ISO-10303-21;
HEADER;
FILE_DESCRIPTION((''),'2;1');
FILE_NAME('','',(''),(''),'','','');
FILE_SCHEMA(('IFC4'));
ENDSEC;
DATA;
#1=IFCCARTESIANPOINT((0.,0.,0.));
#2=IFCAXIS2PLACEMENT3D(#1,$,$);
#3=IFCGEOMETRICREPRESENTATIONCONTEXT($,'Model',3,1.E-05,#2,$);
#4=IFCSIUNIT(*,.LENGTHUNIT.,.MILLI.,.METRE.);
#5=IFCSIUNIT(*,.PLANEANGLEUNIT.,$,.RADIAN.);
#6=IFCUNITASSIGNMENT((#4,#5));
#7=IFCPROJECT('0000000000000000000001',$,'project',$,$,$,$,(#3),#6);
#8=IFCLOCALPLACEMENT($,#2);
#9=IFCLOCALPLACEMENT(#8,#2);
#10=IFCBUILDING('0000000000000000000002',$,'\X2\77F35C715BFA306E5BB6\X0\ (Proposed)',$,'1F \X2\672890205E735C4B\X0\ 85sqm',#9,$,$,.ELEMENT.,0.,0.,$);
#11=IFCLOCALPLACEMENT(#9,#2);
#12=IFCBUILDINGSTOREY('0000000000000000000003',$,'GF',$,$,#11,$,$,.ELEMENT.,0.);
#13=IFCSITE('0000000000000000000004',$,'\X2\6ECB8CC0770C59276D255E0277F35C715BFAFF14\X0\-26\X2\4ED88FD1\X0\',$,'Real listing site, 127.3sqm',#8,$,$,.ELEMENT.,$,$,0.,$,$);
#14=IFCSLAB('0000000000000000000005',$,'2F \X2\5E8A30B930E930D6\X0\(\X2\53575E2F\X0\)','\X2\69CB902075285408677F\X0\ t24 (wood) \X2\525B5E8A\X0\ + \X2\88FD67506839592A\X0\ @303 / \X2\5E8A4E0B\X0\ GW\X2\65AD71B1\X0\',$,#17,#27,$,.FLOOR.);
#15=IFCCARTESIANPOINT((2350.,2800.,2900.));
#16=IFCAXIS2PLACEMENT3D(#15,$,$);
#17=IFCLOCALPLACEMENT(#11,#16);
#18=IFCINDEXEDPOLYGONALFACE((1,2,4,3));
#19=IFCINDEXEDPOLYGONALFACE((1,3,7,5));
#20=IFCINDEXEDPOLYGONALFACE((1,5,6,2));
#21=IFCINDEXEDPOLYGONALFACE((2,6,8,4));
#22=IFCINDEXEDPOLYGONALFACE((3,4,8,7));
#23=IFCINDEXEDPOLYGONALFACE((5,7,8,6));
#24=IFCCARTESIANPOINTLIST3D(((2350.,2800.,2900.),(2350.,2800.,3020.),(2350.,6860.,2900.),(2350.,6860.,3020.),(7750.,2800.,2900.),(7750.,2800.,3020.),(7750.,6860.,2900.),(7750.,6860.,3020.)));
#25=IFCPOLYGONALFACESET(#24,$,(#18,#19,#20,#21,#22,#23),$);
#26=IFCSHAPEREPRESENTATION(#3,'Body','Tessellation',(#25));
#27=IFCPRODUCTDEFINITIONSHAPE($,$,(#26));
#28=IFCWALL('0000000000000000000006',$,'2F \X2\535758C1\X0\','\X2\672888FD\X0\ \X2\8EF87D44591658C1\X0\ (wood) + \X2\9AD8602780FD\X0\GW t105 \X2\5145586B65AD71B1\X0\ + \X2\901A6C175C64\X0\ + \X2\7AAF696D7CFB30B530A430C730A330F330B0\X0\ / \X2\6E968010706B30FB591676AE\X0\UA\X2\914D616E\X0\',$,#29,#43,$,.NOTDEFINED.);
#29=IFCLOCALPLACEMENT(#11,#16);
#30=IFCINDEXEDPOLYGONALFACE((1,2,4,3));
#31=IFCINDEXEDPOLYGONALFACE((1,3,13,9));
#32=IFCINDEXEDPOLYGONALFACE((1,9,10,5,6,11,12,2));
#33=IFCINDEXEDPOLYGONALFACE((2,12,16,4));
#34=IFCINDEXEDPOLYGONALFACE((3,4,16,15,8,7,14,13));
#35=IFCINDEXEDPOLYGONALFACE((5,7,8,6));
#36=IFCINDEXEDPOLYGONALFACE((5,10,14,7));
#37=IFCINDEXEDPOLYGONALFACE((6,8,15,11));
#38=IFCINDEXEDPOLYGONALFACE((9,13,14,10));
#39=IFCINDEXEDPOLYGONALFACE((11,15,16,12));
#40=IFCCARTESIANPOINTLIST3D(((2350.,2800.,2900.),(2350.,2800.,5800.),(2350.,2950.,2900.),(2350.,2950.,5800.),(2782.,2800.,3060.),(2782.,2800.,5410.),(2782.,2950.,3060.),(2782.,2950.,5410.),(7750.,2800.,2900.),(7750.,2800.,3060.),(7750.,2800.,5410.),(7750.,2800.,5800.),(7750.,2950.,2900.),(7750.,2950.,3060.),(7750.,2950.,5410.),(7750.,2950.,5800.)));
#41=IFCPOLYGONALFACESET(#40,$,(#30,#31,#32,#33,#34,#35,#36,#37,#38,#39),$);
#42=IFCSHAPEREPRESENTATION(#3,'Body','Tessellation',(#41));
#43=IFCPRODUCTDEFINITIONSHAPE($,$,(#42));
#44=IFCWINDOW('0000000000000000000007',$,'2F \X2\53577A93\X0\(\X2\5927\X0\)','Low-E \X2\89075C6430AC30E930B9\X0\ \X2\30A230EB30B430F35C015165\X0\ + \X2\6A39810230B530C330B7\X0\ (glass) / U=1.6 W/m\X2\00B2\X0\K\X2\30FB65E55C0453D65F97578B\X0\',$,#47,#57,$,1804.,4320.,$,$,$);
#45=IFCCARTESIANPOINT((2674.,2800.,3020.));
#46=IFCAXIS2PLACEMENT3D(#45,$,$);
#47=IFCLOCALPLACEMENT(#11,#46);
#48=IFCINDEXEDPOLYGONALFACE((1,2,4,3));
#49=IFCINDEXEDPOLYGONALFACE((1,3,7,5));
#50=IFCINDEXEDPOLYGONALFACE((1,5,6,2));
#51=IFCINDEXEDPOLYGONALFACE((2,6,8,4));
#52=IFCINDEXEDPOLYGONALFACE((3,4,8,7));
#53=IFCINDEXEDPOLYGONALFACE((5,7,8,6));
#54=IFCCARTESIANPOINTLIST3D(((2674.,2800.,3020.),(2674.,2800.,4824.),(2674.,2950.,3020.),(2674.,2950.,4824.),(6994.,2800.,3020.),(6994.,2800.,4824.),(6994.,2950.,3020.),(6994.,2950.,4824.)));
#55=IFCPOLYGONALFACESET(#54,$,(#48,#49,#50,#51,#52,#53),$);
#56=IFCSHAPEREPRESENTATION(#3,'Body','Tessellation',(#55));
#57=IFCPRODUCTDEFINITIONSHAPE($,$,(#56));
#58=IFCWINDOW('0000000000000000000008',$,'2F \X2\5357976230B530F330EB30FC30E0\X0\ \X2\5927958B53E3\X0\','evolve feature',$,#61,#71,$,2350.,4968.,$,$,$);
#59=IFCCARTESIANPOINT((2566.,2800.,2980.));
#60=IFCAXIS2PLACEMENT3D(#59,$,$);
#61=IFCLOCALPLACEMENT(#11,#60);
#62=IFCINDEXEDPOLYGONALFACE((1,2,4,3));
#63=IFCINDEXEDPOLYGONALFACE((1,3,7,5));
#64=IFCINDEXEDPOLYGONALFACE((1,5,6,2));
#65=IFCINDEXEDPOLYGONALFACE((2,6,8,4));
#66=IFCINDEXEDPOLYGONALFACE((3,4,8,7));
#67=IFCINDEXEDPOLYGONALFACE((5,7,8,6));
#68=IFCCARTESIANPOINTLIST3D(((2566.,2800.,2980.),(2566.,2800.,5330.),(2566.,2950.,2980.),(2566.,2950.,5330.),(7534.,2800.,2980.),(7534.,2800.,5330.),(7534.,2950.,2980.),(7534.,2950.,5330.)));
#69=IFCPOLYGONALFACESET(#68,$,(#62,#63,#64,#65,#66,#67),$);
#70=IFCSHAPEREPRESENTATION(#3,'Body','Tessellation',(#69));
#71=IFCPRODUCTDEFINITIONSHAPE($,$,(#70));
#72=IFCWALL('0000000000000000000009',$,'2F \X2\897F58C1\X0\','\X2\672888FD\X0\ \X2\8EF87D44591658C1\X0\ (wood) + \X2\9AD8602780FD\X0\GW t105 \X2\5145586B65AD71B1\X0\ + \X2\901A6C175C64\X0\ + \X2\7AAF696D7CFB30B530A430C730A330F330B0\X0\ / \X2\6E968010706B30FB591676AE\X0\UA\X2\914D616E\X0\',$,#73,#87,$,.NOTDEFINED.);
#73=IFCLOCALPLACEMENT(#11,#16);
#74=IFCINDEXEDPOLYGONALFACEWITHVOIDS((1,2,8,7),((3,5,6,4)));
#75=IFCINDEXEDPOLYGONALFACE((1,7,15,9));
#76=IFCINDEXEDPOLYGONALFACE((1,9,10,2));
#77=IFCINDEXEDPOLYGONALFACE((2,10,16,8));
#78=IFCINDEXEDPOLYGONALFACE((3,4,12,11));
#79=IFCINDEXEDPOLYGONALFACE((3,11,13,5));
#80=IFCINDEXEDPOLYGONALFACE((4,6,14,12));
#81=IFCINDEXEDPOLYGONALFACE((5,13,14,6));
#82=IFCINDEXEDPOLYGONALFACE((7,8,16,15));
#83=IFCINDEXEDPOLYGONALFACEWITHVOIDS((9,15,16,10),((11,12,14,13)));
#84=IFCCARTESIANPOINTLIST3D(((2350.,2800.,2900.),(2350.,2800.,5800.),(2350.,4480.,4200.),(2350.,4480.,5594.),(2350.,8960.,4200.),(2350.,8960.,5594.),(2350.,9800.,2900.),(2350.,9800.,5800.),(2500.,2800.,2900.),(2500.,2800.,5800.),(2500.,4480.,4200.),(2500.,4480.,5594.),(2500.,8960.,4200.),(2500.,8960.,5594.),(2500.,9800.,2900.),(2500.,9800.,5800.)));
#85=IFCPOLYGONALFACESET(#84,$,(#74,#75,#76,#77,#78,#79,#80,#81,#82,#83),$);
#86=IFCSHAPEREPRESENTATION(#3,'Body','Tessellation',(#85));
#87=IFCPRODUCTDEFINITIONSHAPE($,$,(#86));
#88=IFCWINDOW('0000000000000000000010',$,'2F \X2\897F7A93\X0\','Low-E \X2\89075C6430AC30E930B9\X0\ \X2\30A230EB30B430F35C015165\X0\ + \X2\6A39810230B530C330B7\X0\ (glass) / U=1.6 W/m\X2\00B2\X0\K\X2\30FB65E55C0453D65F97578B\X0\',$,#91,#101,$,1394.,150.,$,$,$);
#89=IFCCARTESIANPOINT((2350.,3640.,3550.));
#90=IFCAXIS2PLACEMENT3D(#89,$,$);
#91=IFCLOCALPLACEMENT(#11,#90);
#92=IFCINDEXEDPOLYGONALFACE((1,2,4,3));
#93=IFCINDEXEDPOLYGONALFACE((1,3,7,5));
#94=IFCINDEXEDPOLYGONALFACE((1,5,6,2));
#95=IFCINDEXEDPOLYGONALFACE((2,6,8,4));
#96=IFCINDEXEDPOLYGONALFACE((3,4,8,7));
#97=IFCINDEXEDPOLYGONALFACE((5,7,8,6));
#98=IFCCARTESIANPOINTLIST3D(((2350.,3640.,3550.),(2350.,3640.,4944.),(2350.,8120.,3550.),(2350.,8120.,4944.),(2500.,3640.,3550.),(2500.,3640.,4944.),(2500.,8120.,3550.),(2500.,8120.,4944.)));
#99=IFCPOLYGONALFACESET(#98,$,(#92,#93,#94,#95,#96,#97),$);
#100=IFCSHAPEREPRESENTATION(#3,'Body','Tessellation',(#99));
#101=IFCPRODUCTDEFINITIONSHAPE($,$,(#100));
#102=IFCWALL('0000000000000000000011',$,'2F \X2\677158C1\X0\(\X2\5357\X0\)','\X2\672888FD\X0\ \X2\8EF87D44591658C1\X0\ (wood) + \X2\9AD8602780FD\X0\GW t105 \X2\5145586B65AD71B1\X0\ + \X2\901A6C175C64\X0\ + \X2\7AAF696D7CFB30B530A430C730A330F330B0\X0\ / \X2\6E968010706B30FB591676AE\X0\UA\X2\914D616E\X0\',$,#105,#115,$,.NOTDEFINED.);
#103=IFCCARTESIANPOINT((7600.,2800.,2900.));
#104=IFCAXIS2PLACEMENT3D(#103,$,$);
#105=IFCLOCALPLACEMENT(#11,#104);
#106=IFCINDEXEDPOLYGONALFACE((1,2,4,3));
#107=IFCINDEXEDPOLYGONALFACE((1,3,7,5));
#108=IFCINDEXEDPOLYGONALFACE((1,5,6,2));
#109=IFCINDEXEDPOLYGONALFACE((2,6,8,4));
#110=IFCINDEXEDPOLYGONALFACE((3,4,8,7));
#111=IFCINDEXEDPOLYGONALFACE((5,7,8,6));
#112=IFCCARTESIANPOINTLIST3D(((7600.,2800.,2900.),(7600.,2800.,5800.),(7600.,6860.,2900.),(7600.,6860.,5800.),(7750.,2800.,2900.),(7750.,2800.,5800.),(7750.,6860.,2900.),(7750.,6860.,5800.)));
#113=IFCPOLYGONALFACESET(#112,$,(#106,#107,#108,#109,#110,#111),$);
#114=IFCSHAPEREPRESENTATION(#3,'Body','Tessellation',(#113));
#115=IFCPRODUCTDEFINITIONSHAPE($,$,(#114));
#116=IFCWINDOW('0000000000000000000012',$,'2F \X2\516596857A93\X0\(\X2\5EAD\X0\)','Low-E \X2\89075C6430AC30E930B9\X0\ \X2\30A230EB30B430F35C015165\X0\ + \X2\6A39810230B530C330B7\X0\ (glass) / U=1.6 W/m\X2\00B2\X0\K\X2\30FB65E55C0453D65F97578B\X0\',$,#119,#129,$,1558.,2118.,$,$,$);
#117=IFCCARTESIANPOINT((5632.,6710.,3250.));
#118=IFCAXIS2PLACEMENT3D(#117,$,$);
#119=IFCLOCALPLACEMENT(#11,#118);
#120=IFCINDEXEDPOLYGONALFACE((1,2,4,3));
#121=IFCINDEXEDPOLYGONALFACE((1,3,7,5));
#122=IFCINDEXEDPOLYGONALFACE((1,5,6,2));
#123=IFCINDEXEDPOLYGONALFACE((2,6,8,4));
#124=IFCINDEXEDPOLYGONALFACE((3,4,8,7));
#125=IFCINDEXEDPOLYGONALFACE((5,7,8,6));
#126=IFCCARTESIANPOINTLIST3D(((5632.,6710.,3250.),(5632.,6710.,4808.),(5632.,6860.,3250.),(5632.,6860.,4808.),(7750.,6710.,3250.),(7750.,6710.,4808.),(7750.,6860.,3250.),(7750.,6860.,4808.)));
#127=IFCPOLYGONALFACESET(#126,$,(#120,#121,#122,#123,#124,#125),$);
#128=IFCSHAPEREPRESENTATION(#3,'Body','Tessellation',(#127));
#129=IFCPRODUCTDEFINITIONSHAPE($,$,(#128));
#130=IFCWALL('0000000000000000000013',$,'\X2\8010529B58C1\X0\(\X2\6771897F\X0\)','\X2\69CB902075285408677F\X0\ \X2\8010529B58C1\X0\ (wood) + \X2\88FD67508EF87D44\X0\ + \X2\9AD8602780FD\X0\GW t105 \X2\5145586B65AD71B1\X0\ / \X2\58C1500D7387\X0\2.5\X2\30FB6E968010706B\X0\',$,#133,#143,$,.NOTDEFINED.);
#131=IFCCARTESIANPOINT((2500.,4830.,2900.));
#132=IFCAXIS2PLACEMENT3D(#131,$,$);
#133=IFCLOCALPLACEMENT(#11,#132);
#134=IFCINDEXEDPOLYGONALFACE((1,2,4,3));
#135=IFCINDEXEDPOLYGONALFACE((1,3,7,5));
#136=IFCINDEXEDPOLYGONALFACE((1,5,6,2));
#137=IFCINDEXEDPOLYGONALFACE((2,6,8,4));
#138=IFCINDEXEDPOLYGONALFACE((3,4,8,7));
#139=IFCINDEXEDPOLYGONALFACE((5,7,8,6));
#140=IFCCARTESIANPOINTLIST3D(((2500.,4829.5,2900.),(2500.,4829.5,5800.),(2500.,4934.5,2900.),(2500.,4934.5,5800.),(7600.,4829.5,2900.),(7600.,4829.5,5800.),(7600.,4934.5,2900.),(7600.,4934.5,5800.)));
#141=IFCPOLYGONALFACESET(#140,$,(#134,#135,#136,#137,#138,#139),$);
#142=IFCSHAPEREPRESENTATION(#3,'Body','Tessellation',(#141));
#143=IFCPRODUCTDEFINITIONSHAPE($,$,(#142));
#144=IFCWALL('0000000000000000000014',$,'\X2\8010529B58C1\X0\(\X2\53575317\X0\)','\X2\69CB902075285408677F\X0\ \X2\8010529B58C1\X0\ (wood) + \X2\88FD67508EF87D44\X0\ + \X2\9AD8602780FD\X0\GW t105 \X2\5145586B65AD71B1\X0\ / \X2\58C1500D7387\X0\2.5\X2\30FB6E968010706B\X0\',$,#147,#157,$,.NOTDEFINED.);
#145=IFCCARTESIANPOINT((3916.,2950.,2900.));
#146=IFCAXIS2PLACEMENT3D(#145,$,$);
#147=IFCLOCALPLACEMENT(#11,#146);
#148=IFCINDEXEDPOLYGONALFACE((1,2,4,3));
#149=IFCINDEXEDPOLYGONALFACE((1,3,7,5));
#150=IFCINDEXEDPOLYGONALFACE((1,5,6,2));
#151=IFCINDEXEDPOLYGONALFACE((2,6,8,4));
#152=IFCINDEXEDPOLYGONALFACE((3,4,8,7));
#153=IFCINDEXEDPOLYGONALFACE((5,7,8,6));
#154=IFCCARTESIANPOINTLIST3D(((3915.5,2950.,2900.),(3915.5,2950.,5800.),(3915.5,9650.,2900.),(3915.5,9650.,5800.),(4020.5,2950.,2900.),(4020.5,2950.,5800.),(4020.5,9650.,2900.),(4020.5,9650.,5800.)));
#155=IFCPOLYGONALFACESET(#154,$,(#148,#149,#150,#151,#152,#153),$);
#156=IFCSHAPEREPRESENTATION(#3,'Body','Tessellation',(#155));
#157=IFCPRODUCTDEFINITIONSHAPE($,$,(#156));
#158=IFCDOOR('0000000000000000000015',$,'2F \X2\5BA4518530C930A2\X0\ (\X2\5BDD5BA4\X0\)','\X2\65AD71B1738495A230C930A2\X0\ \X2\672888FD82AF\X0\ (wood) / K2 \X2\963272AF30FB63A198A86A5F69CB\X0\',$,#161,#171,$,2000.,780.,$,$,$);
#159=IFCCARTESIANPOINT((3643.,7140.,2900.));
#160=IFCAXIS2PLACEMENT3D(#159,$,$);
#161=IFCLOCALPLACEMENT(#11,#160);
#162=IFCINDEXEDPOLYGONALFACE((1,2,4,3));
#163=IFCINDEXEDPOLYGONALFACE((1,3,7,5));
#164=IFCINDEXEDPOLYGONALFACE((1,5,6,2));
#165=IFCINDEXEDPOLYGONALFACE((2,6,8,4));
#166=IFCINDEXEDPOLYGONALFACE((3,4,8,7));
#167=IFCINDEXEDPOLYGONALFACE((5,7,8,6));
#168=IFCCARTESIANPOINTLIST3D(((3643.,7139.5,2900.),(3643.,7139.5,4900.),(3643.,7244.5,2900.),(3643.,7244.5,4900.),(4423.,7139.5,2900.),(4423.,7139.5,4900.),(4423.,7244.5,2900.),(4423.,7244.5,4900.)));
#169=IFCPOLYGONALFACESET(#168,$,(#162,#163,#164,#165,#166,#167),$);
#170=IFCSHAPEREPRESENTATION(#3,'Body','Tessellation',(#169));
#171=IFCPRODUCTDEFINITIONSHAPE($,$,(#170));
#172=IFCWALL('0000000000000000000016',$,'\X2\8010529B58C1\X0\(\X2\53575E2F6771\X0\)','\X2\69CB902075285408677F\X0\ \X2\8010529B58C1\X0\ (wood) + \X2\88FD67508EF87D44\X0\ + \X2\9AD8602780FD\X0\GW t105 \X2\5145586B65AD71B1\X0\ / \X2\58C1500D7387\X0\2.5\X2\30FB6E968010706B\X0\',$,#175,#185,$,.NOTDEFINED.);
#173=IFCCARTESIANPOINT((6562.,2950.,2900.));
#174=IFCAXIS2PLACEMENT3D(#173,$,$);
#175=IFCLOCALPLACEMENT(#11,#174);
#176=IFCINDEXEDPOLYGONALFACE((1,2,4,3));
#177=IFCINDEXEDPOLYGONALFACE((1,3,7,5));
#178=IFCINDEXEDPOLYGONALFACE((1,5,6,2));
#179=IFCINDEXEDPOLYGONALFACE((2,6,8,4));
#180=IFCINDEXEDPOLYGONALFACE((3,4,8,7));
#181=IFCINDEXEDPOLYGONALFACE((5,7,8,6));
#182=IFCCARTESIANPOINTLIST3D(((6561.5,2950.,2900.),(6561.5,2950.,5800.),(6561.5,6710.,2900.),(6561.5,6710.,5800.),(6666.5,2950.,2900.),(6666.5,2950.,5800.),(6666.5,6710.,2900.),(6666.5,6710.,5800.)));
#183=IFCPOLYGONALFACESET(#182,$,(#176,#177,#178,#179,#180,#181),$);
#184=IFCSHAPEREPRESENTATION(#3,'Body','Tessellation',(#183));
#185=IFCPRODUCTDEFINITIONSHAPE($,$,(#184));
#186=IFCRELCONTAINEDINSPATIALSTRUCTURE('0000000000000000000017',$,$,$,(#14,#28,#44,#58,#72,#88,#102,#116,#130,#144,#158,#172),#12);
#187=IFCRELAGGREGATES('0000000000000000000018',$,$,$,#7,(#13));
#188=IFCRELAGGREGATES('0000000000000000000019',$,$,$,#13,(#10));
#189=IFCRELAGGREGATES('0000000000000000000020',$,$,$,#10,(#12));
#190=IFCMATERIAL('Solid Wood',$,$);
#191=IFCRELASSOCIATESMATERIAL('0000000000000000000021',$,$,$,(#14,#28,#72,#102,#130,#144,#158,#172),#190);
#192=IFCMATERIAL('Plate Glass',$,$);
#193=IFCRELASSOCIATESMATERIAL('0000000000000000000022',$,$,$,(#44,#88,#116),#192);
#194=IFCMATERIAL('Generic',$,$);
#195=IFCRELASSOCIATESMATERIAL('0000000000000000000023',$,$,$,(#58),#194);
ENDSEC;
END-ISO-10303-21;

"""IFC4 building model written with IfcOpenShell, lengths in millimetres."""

from ifc_helpers import new_model, si_unit, frame, frame_2d, origin, place, context, project, spatial, rectangle, extrude, material, element, fill, save


model = new_model("IFC4")

# Units and contexts
model_context = context("Model", 3, precision=1e-05, world=origin())
ifc_project = project(units=[si_unit("LENGTHUNIT", "METRE", prefix="MILLI"), si_unit("PLANEANGLEUNIT", "RADIAN")], contexts=[model_context])

# Site, building, storey
site_placement = place(None, origin())
site = spatial("IfcSite", under=ifc_project, at=site_placement, Name="滋賀県大津市石山寺４-26付近", ObjectType="Real listing site, 127.3sqm", CompositionType="ELEMENT", RefElevation=0.0)
building_placement = place(site_placement, origin())
building = spatial("IfcBuilding", under=site, at=building_placement, Name="石山寺の家 (Proposed)", ObjectType="1F 木造平屋 85sqm", CompositionType="ELEMENT", ElevationOfRefHeight=0.0, ElevationOfTerrain=0.0)
storey_placement = place(building_placement, origin())
storey = spatial("IfcBuildingStorey", under=building, at=storey_placement, Name="GF", CompositionType="ELEMENT", Elevation=0.0)

# Slab
ifc_material_1 = material(Name="Solid Wood")
slab_placement = place(storey_placement, frame((2350.0, 2800.0, 2900.0)))
element("IfcSlab", 1, at=slab_placement, inside=storey, material=ifc_material_1, Name="2F 床スラブ(南帯)", Description="構造用合板 t24 (wood) 剛床 + 製材根太 @303 / 床下 GW断熱", PredefinedType="FLOOR", context=model_context, shape_type="SweptSolid", body=[
    extrude(rectangle(XDim=5400.0, YDim=4060.0, at=frame_2d((2700.0, 2030.0))), frame((2350.0, 2800.0, 2900.0)), (0.0, 0.0, 1.0), 120.0),
])

# Wall, openings, windows
wall_1_placement = place(storey_placement, frame((2350.0, 2800.0, 2900.0)))
wall_1 = element("IfcWall", 2, at=wall_1_placement, inside=storey, material=ifc_material_1, Name="2F 南壁", Description="木製 軸組外壁 (wood) + 高性能GW t105 充填断熱 + 通気層 + 窯業系サイディング / 準耐火・外皮UA配慮", PredefinedType="NOTDEFINED", context=model_context, shape_type="SweptSolid", body=[
    extrude(rectangle(XDim=5400.0, YDim=150.0, at=frame_2d((2700.0, 75.0))), frame((2350.0, 2800.0, 2900.0)), (0.0, 0.0, 1.0), 2900.0),
])
opening_1_placement = place(storey_placement, frame((2674.0, 2800.0, 3020.0)))
opening_1 = element("IfcOpeningElement", 3, at=opening_1_placement, cuts=wall_1, PredefinedType="NOTDEFINED", context=model_context, shape_type="SweptSolid", body=[
    extrude(rectangle(XDim=4320.0, YDim=150.0, at=frame_2d((2160.0, 75.0))), frame((2674.0, 2800.0, 3020.0)), (0.0, 0.0, 1.0), 1804.0),
])
opening_2_placement = place(storey_placement, frame((2566.0, 2800.0, 2980.0)))
opening_2 = element("IfcOpeningElement", 4, at=opening_2_placement, cuts=wall_1, PredefinedType="NOTDEFINED", context=model_context, shape_type="SweptSolid", body=[
    extrude(rectangle(XDim=4968.0, YDim=150.0, at=frame_2d((2484.0, 75.0))), frame((2566.0, 2800.0, 2980.0)), (0.0, 0.0, 1.0), 2350.0),
])
ifc_material_2 = material(Name="Plate Glass")
window_1_placement = place(storey_placement, frame((2674.0, 2800.0, 3020.0)))
window_1 = element("IfcWindow", 5, at=window_1_placement, inside=storey, material=ifc_material_2, Name="2F 南窓(大)", Description="Low-E 複層ガラス アルゴン封入 + 樹脂サッシ (glass) / U=1.6 W/m²K・日射取得型", OverallHeight=1804.0, OverallWidth=4320.0, context=model_context, shape_type="SweptSolid", body=[
    extrude(rectangle(XDim=4320.0, YDim=150.0, at=frame_2d((2160.0, 75.0))), frame((2674.0, 2800.0, 3020.0)), (0.0, 0.0, 1.0), 1804.0),
])
fill(opening_1, window_1)
ifc_material_3 = material(Name="Generic")
window_2_placement = place(storey_placement, frame((2566.0, 2800.0, 2980.0)))
window_2 = element("IfcWindow", 6, at=window_2_placement, inside=storey, material=ifc_material_3, Name="2F 南面サンルーム 大開口", Description="evolve feature", OverallHeight=2350.0, OverallWidth=4968.0, context=model_context, shape_type="SweptSolid", body=[
    extrude(rectangle(XDim=4968.0, YDim=150.0, at=frame_2d((2484.0, 75.0))), frame((2566.0, 2800.0, 2980.0)), (0.0, 0.0, 1.0), 2350.0),
])
fill(opening_2, window_2)

# Walls, openings, windows
wall_2_placement = place(storey_placement, frame((2350.0, 2800.0, 2900.0)))
wall_2 = element("IfcWall", 7, at=wall_2_placement, inside=storey, material=ifc_material_1, Name="2F 西壁", Description="木製 軸組外壁 (wood) + 高性能GW t105 充填断熱 + 通気層 + 窯業系サイディング / 準耐火・外皮UA配慮", PredefinedType="NOTDEFINED", context=model_context, shape_type="SweptSolid", body=[
    extrude(rectangle(XDim=150.0, YDim=7000.0, at=frame_2d((75.0, 3500.0))), frame((2350.0, 2800.0, 2900.0)), (0.0, 0.0, 1.0), 2900.0),
])
opening_3_placement = place(storey_placement, frame((2350.0, 3640.0, 3550.0)))
opening_3 = element("IfcOpeningElement", 8, at=opening_3_placement, cuts=wall_2, PredefinedType="NOTDEFINED", context=model_context, shape_type="SweptSolid", body=[
    extrude(rectangle(XDim=150.0, YDim=4480.0, at=frame_2d((75.0, 2240.0))), frame((2350.0, 3640.0, 3550.0)), (0.0, 0.0, 1.0), 1394.0),
])
window_3_placement = place(storey_placement, frame((2350.0, 3640.0, 3550.0)))
window_3 = element("IfcWindow", 9, at=window_3_placement, inside=storey, material=ifc_material_2, Name="2F 西窓", Description="Low-E 複層ガラス アルゴン封入 + 樹脂サッシ (glass) / U=1.6 W/m²K・日射取得型", OverallHeight=1394.0, OverallWidth=150.0, context=model_context, shape_type="SweptSolid", body=[
    extrude(rectangle(XDim=150.0, YDim=4480.0, at=frame_2d((75.0, 2240.0))), frame((2350.0, 3640.0, 3550.0)), (0.0, 0.0, 1.0), 1394.0),
])
fill(opening_3, window_3)
wall_3_placement = place(storey_placement, frame((7600.0, 2800.0, 2900.0)))
wall_3 = element("IfcWall", 10, at=wall_3_placement, inside=storey, material=ifc_material_1, Name="2F 東壁(南)", Description="木製 軸組外壁 (wood) + 高性能GW t105 充填断熱 + 通気層 + 窯業系サイディング / 準耐火・外皮UA配慮", PredefinedType="NOTDEFINED", context=model_context, shape_type="SweptSolid", body=[
    extrude(rectangle(XDim=150.0, YDim=4060.0, at=frame_2d((75.0, 2030.0))), frame((7600.0, 2800.0, 2900.0)), (0.0, 0.0, 1.0), 2900.0),
])
opening_4_placement = place(storey_placement, frame((5632.0, 6710.0, 3250.0)))
opening_4 = element("IfcOpeningElement", 11, at=opening_4_placement, cuts=wall_3, PredefinedType="NOTDEFINED", context=model_context, shape_type="SweptSolid", body=[
    extrude(rectangle(XDim=2118.0, YDim=150.0, at=frame_2d((1059.0, 75.0))), frame((5632.0, 6710.0, 3250.0)), (0.0, 0.0, 1.0), 1558.0),
])
window_4_placement = place(storey_placement, frame((5632.0, 6710.0, 3250.0)))
window_4 = element("IfcWindow", 12, at=window_4_placement, inside=storey, material=ifc_material_2, Name="2F 入隅窓(庭)", Description="Low-E 複層ガラス アルゴン封入 + 樹脂サッシ (glass) / U=1.6 W/m²K・日射取得型", OverallHeight=1558.0, OverallWidth=2118.0, context=model_context, shape_type="SweptSolid", body=[
    extrude(rectangle(XDim=2118.0, YDim=150.0, at=frame_2d((1059.0, 75.0))), frame((5632.0, 6710.0, 3250.0)), (0.0, 0.0, 1.0), 1558.0),
])
fill(opening_4, window_4)

# Wall
wall_4_placement = place(storey_placement, frame((2500.0, 4830.0, 2900.0)))
element("IfcWall", 13, at=wall_4_placement, inside=storey, material=ifc_material_1, Name="耐力壁(東西)", Description="構造用合板 耐力壁 (wood) + 製材軸組 + 高性能GW t105 充填断熱 / 壁倍率2.5・準耐火", PredefinedType="NOTDEFINED", context=model_context, shape_type="SweptSolid", body=[
    extrude(rectangle(XDim=5100.0, YDim=105.0, at=frame_2d((2550.0, 52.0))), frame((2500.0, 4830.0, 2900.0)), (0.0, 0.0, 1.0), 2900.0),
])

# Wall, opening, door
wall_5_placement = place(storey_placement, frame((3916.0, 2950.0, 2900.0)))
wall_5 = element("IfcWall", 14, at=wall_5_placement, inside=storey, material=ifc_material_1, Name="耐力壁(南北)", Description="構造用合板 耐力壁 (wood) + 製材軸組 + 高性能GW t105 充填断熱 / 壁倍率2.5・準耐火", PredefinedType="NOTDEFINED", context=model_context, shape_type="SweptSolid", body=[
    extrude(rectangle(XDim=105.0, YDim=6700.0, at=frame_2d((52.0, 3350.0))), frame((3916.0, 2950.0, 2900.0)), (0.0, 0.0, 1.0), 2900.0),
])
opening_5_placement = place(storey_placement, frame((3643.0, 7140.0, 2900.0)))
opening_5 = element("IfcOpeningElement", 15, at=opening_5_placement, cuts=wall_5, PredefinedType="NOTDEFINED", context=model_context, shape_type="SweptSolid", body=[
    extrude(rectangle(XDim=780.0, YDim=105.0, at=frame_2d((390.0, 52.0))), frame((3643.0, 7140.0, 2900.0)), (0.0, 0.0, 1.0), 2000.0),
])
door_placement = place(storey_placement, frame((3643.0, 7140.0, 2900.0)))
door = element("IfcDoor", 16, at=door_placement, inside=storey, material=ifc_material_1, Name="2F 室内ドア (寝室)", Description="断熱玄関ドア 木製芯 (wood) / K2 防犯・採風機構", OverallHeight=2000.0, OverallWidth=780.0, context=model_context, shape_type="SweptSolid", body=[
    extrude(rectangle(XDim=780.0, YDim=105.0, at=frame_2d((390.0, 52.0))), frame((3643.0, 7140.0, 2900.0)), (0.0, 0.0, 1.0), 2000.0),
])
fill(opening_5, door)

# Wall
wall_6_placement = place(storey_placement, frame((6562.0, 2950.0, 2900.0)))
element("IfcWall", 17, at=wall_6_placement, inside=storey, material=ifc_material_1, Name="耐力壁(南帯東)", Description="構造用合板 耐力壁 (wood) + 製材軸組 + 高性能GW t105 充填断熱 / 壁倍率2.5・準耐火", PredefinedType="NOTDEFINED", context=model_context, shape_type="SweptSolid", body=[
    extrude(rectangle(XDim=105.0, YDim=3760.0, at=frame_2d((52.0, 1880.0))), frame((6562.0, 2950.0, 2900.0)), (0.0, 0.0, 1.0), 2900.0),
])

save(model, "model.ifc")
